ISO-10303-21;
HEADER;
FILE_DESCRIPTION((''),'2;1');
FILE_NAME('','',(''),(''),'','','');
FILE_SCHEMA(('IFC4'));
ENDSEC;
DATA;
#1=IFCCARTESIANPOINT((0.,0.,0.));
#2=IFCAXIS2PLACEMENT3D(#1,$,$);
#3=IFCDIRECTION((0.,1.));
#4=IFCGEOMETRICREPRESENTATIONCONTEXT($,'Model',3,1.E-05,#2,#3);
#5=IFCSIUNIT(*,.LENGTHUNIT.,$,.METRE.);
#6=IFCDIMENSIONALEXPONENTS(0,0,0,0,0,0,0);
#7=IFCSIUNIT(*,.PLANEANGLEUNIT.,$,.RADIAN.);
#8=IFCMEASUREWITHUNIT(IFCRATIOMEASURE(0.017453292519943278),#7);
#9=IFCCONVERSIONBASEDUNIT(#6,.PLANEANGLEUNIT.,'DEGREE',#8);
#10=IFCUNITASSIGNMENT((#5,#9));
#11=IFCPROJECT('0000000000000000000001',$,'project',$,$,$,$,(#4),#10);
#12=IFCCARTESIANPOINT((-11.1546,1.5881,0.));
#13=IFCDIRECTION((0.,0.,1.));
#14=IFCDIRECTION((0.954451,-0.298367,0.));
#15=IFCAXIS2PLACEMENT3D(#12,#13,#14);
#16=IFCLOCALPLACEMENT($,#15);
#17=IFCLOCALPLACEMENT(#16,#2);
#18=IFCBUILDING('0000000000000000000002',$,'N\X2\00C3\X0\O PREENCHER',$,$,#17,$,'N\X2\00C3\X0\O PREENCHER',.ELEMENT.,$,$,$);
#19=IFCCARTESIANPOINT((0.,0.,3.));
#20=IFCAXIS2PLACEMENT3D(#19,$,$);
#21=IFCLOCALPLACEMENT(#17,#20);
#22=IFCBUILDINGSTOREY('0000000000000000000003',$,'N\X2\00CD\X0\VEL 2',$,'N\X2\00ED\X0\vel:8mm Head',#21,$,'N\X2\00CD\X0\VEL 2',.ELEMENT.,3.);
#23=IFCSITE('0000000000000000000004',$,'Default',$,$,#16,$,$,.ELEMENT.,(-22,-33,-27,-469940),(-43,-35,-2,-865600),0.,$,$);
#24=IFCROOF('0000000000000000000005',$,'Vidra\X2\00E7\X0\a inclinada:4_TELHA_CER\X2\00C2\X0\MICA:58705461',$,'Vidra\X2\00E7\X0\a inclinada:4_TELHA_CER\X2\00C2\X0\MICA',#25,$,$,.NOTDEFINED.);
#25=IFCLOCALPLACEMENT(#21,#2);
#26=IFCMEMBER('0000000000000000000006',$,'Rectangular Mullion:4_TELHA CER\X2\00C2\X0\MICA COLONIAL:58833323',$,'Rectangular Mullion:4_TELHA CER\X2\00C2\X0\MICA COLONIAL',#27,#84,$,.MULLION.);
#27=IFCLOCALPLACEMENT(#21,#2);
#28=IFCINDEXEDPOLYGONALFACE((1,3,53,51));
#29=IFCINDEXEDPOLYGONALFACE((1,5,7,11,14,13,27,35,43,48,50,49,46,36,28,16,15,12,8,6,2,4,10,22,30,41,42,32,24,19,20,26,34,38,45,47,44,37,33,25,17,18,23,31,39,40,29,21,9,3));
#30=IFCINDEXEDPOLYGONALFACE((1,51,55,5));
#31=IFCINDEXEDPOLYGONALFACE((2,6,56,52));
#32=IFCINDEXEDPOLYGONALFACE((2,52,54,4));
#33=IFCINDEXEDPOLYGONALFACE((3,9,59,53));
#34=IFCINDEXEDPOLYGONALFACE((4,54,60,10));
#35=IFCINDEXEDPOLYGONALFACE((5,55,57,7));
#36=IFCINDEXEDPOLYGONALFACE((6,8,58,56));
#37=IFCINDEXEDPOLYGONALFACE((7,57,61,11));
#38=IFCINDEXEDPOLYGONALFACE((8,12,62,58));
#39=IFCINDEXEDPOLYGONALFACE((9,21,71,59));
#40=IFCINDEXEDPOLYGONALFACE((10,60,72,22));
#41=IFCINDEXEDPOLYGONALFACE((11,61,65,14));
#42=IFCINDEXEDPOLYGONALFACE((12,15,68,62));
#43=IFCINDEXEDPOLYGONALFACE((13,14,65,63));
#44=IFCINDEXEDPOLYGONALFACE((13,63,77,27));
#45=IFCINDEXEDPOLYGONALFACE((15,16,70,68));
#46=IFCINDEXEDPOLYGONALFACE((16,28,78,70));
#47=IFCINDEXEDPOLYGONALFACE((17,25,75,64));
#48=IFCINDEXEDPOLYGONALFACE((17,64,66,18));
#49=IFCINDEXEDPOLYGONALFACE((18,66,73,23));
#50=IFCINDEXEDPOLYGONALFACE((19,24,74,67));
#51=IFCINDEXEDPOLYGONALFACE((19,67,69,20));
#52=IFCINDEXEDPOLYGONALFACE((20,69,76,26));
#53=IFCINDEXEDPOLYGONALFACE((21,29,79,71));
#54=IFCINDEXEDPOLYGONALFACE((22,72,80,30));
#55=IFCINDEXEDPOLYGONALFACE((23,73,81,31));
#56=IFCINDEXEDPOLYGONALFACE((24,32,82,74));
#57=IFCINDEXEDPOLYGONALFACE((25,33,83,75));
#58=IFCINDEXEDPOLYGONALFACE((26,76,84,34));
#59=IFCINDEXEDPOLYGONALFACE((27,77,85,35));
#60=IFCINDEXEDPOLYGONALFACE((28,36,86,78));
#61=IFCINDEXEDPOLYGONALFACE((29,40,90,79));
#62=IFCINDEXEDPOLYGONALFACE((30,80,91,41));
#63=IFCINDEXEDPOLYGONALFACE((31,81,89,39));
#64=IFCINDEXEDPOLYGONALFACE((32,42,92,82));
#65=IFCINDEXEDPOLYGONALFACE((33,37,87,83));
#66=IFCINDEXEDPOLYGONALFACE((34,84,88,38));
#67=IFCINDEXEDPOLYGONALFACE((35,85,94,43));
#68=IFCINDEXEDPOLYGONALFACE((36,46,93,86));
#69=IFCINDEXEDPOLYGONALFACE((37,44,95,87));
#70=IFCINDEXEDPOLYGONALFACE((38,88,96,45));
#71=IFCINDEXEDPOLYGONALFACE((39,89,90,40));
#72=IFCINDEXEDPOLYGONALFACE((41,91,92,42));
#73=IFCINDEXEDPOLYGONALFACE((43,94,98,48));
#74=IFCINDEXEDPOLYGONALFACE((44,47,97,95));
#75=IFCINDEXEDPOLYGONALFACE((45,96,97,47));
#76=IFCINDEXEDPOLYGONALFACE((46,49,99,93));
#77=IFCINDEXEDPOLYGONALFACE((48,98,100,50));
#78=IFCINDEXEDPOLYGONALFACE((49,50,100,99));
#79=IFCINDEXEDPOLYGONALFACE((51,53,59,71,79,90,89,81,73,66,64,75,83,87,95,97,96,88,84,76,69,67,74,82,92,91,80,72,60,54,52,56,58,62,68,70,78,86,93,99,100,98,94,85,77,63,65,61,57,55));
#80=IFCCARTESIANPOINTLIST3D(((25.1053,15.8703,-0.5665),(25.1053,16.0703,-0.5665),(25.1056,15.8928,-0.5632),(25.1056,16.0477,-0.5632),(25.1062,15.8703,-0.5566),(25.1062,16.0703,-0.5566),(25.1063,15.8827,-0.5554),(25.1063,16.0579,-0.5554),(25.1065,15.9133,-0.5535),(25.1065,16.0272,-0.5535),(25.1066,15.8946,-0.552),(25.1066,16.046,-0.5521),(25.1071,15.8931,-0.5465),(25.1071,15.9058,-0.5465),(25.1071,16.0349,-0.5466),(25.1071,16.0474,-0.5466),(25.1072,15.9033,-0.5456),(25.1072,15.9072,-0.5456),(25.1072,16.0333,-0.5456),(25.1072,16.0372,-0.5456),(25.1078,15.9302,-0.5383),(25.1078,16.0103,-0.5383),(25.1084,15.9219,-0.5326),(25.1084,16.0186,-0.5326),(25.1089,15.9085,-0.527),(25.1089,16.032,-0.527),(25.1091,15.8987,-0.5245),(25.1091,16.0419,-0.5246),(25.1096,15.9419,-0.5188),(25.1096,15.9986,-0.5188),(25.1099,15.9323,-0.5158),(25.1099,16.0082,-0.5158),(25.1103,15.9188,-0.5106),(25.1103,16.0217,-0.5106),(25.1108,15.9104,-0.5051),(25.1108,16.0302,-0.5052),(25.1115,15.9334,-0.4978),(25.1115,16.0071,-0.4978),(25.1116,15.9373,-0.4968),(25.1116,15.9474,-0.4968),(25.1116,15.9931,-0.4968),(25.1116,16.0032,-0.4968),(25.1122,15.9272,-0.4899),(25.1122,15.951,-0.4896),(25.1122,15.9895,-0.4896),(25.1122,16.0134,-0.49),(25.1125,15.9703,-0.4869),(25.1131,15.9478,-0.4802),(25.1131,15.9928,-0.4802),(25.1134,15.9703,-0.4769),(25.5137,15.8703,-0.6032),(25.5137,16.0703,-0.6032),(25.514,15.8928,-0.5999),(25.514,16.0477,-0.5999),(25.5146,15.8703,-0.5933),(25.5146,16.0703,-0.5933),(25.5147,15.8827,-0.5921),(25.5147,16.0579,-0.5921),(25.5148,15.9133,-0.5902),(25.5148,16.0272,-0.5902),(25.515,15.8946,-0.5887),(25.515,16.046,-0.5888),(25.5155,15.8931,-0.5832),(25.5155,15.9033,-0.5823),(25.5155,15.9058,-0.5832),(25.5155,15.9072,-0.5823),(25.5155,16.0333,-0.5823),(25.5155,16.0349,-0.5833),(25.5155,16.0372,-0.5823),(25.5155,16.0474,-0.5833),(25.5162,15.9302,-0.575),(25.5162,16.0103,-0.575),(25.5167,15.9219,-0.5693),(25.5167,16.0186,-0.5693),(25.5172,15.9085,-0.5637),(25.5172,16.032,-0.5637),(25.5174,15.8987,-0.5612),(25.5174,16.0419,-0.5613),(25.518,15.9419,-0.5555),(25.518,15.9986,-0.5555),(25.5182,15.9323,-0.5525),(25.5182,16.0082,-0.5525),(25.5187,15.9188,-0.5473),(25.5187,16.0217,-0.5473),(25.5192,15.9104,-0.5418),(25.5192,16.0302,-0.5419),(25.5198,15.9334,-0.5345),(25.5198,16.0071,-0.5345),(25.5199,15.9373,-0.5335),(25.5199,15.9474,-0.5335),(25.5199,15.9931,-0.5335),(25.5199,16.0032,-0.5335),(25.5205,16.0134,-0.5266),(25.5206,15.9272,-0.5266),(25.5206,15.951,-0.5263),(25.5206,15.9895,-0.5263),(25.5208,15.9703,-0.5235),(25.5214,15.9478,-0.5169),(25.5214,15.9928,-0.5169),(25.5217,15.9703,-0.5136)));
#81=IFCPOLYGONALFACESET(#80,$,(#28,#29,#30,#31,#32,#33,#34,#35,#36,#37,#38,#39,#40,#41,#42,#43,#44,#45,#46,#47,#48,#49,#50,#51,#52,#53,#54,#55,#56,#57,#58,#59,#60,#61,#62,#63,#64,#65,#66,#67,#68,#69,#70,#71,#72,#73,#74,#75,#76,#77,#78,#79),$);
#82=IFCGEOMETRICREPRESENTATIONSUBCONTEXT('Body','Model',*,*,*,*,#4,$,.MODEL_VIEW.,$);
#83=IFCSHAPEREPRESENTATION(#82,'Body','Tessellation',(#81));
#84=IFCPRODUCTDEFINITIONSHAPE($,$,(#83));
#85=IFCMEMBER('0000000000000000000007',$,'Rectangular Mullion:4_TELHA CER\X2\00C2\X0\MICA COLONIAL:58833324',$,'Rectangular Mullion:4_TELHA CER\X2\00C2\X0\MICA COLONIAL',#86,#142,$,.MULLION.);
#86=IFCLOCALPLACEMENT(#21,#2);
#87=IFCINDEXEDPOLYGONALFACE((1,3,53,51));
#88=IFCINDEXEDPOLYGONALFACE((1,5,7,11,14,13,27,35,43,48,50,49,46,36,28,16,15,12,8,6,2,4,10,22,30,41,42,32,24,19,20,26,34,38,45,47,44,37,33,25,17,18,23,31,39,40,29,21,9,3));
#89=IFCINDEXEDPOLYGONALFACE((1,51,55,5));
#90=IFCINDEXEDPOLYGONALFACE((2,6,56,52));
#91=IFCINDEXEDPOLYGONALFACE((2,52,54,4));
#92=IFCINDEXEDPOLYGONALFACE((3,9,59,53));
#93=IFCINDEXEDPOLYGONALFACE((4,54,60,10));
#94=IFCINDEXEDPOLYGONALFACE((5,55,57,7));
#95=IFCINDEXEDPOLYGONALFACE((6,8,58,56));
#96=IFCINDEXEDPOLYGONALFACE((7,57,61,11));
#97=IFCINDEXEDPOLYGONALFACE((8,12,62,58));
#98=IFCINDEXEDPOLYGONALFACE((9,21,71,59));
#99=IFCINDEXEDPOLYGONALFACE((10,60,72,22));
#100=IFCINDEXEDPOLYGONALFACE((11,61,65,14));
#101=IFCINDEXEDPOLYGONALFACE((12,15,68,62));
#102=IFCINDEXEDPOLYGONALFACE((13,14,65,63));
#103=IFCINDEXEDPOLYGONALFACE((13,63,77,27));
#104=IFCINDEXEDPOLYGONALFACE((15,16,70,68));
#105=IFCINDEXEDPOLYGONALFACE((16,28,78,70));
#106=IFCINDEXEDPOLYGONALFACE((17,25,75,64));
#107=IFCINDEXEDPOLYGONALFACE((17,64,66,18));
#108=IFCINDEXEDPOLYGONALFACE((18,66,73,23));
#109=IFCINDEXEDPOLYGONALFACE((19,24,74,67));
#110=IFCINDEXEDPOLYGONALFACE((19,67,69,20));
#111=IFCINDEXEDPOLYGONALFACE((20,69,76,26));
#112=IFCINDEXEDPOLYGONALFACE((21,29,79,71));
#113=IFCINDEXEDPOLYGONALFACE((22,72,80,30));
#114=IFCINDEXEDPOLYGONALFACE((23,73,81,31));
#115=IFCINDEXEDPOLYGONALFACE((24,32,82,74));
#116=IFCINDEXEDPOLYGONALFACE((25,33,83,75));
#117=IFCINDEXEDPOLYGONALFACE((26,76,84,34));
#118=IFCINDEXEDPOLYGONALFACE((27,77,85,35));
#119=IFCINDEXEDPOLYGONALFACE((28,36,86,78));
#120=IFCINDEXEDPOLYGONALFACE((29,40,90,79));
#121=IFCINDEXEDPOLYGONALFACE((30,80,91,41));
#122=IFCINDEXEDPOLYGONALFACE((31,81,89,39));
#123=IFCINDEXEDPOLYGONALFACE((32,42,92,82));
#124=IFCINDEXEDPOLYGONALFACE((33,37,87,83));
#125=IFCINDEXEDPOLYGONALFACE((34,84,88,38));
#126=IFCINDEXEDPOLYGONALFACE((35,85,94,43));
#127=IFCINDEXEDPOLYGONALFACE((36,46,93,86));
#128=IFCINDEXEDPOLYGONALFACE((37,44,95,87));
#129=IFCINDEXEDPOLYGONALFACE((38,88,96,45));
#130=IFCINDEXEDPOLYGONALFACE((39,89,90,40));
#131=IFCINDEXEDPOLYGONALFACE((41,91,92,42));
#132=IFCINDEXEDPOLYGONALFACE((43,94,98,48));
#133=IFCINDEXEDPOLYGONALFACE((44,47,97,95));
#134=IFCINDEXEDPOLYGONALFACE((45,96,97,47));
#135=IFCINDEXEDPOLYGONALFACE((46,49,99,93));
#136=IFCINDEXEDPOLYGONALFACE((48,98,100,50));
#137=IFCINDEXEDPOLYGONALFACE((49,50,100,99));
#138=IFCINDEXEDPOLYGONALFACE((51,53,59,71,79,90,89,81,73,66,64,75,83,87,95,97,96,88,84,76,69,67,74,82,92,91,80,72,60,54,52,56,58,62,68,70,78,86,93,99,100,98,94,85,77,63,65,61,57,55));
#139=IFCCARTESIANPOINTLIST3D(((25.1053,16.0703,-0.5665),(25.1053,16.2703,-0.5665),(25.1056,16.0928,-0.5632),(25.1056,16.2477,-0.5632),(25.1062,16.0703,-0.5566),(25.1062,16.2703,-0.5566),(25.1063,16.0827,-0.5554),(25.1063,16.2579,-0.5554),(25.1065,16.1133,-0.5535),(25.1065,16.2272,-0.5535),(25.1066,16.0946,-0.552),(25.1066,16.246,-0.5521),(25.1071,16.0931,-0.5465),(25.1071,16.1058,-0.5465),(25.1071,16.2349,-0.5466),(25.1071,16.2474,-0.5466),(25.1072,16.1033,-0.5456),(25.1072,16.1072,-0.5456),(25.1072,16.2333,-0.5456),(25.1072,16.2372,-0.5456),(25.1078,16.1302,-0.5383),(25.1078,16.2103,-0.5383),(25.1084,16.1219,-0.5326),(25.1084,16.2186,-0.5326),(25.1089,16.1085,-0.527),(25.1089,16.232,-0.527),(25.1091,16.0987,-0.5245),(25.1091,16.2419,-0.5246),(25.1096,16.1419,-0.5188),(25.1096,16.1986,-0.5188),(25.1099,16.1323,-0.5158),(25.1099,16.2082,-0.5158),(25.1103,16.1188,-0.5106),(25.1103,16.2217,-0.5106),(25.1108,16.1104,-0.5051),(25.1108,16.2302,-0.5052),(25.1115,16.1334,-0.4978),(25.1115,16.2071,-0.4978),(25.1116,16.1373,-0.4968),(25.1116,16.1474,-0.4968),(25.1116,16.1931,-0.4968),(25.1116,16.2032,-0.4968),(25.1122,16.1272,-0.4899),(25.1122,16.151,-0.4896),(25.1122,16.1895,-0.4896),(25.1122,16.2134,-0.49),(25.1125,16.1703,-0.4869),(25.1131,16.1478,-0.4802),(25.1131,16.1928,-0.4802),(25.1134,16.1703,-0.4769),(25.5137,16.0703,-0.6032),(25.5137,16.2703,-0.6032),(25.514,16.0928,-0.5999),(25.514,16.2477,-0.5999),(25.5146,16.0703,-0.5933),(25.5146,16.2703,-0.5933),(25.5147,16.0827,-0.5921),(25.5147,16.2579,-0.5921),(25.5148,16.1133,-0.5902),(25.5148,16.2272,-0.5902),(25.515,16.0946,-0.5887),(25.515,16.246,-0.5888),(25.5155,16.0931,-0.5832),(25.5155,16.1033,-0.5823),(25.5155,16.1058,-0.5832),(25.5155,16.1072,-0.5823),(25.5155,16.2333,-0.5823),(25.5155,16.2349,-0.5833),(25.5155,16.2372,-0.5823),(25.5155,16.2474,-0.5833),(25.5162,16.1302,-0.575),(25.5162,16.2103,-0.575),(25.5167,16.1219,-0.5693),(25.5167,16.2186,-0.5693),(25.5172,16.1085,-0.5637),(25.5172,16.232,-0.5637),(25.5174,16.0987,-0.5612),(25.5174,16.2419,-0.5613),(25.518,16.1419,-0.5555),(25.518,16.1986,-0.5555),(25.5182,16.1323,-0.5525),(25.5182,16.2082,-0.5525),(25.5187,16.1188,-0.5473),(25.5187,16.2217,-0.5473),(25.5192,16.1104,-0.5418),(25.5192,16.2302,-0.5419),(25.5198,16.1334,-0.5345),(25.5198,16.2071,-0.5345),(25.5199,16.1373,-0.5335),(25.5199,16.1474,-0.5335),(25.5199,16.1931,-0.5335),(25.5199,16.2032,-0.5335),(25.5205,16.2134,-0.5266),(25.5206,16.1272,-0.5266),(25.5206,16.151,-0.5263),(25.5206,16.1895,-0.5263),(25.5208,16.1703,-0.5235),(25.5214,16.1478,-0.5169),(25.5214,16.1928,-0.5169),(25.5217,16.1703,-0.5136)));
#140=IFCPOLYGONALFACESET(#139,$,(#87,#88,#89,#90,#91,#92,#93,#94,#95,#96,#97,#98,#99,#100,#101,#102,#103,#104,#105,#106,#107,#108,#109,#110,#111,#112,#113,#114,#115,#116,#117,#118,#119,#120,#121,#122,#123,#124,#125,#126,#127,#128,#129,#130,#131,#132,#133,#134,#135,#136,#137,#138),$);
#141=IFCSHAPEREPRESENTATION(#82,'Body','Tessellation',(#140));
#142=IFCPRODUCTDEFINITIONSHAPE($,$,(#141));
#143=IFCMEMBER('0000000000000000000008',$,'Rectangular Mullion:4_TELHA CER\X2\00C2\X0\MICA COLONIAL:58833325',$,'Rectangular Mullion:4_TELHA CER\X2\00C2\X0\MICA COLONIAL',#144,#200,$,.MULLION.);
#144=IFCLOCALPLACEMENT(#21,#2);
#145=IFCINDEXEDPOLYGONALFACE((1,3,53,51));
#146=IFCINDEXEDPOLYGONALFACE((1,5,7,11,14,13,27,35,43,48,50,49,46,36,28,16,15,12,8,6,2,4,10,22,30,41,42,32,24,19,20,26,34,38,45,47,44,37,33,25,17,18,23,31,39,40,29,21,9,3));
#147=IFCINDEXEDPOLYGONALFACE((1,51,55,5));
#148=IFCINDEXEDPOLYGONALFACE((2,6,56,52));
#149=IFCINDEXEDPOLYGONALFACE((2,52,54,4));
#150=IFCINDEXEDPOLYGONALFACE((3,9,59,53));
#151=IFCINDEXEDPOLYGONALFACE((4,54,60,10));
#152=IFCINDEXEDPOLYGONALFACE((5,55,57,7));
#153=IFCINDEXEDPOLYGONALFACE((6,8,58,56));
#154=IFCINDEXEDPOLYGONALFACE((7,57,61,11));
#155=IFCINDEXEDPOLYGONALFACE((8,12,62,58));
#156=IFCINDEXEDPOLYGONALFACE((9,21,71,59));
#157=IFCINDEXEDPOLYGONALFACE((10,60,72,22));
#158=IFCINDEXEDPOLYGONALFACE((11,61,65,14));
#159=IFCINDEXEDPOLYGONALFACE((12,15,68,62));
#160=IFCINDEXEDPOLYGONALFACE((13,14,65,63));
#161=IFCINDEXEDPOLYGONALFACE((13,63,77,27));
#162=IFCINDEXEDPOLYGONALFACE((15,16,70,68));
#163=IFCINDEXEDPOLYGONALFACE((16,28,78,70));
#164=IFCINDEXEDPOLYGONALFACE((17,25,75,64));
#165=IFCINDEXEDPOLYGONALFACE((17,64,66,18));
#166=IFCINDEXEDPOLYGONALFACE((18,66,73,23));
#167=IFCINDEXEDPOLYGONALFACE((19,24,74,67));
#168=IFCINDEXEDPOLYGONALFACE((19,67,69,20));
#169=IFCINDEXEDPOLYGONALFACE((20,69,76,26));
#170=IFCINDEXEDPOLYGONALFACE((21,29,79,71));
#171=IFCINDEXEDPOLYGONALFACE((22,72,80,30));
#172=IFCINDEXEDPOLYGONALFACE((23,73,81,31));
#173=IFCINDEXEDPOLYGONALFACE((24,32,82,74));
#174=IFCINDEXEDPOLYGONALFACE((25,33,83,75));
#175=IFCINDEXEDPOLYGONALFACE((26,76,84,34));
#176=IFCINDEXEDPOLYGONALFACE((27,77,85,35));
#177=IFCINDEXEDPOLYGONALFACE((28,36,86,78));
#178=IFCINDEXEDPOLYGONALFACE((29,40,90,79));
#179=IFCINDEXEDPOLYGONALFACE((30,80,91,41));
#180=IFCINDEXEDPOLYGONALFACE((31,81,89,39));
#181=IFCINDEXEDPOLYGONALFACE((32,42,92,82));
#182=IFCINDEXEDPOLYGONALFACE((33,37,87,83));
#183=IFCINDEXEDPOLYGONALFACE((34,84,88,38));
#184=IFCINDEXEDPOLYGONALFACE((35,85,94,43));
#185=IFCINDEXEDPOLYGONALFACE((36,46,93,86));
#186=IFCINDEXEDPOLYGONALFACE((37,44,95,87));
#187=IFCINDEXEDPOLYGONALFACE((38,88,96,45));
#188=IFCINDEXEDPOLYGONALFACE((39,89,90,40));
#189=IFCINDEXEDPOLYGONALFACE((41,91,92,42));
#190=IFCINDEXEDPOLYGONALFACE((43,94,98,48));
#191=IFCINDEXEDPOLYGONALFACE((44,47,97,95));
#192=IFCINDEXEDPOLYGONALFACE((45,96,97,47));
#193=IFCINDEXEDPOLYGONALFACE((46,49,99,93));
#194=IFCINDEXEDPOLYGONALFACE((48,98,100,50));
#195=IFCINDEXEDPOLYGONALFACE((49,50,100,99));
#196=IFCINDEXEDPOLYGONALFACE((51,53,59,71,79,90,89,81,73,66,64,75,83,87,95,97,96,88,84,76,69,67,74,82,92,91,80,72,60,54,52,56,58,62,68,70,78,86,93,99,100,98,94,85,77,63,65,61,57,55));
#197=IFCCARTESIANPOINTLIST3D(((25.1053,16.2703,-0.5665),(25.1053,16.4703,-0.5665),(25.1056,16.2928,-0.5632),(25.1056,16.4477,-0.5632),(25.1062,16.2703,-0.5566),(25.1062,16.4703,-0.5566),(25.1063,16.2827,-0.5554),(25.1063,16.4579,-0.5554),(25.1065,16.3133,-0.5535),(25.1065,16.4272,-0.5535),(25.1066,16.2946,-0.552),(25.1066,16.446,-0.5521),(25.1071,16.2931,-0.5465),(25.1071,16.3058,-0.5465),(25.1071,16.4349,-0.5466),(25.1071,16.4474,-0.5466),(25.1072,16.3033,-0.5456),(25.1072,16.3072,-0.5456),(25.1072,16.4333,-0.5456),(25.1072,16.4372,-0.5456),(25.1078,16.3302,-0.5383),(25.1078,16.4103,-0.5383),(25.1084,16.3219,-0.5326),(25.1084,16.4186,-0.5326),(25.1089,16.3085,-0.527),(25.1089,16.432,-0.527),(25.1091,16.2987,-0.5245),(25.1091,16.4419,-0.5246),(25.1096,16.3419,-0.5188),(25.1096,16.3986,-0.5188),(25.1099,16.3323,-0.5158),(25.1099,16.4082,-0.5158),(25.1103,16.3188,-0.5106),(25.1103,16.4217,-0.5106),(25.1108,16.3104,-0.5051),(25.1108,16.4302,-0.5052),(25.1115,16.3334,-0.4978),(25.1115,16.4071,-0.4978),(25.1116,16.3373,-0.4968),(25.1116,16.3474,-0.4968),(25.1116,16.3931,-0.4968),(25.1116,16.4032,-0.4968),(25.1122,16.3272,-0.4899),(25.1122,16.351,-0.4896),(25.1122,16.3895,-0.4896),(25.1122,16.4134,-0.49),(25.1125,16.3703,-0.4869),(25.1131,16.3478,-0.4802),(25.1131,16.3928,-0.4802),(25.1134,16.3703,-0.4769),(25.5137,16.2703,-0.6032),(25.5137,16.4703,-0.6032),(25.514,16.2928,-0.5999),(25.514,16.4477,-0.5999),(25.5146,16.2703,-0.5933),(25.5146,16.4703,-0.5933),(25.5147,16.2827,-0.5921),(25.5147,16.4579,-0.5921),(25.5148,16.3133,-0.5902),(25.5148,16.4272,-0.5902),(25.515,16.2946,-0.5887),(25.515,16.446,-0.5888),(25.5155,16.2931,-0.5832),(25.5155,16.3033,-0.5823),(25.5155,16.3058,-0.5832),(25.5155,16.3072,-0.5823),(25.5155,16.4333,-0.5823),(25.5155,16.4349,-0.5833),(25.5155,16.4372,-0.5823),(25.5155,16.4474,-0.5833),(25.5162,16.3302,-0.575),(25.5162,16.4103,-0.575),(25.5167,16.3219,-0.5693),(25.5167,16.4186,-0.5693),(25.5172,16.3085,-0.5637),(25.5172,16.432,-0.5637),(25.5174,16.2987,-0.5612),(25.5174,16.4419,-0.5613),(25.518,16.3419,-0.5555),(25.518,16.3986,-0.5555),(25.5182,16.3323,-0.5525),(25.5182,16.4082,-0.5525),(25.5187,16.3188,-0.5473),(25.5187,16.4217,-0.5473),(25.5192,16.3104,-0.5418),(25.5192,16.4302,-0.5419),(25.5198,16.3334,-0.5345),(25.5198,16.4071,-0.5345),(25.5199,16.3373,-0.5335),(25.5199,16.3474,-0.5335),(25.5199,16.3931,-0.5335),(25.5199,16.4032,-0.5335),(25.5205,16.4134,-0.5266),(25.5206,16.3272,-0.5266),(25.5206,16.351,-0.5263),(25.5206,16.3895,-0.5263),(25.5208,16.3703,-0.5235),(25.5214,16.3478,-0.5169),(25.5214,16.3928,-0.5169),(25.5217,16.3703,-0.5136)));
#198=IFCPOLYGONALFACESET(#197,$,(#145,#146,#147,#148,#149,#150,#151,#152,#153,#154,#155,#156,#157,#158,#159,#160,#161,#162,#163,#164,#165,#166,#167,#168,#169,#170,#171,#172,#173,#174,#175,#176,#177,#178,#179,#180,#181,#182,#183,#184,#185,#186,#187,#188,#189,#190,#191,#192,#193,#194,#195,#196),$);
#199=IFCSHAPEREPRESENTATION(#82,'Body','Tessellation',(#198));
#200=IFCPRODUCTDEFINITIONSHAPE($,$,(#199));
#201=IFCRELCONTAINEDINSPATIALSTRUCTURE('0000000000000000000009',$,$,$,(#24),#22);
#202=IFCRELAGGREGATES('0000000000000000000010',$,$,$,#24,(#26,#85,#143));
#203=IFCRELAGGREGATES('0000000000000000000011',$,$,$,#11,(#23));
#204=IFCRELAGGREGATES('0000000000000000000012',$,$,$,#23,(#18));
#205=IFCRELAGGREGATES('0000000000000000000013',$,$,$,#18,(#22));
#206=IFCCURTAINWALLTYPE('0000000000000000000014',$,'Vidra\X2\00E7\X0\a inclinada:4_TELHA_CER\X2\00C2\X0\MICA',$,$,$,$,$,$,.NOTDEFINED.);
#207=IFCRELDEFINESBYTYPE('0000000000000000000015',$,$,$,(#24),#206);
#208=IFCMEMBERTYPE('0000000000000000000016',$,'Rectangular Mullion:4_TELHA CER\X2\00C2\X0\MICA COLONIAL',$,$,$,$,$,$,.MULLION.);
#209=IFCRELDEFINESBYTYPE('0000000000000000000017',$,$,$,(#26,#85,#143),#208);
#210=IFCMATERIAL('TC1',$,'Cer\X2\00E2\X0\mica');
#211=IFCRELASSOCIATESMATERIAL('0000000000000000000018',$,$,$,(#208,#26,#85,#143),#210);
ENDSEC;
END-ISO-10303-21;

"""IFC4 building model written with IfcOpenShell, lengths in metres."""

from ifc_helpers import new_model, entity, si_unit, converted_unit, direction, frame, origin, place, context, subcontext, project, spatial, line, arc, indexed_curve, outline, extrude, source, transform, mapped, material, type_object, type_shapes, element, aggregate, save


model = new_model("IFC4")

# Units and contexts
model_context = context("Model", 3, precision=1e-05, world=origin(), true_north=direction((0.0, 1.0)))
body_context = subcontext(model_context, "Body", "Model", "MODEL_VIEW")
ifc_project = project(units=[si_unit("LENGTHUNIT", "METRE"), converted_unit("PLANEANGLEUNIT", "DEGREE", entity("IfcRatioMeasure", 0.017453292519943278), si_unit("PLANEANGLEUNIT", "RADIAN"), dimensions=[0, 0, 0, 0, 0, 0, 0])], contexts=[model_context])

# Site, building, storey
site_placement = place(None, frame((-11.1546, 1.5881, 0.0), z_axis=(0.0, 0.0, 1.0), x_axis=(0.954451, -0.298367, 0.0)))
site = spatial("IfcSite", under=ifc_project, at=site_placement, Name="Default", CompositionType="ELEMENT", RefLatitude=(-22, -33, -27, -469940), RefLongitude=(-43, -35, -2, -865600), RefElevation=0.0)
building_placement = place(site_placement, origin())
building = spatial("IfcBuilding", under=site, at=building_placement, Name="NÃO PREENCHER", LongName="NÃO PREENCHER", CompositionType="ELEMENT")
storey_placement = place(building_placement, frame((0.0, 0.0, 3.0)))
storey = spatial("IfcBuildingStorey", under=building, at=storey_placement, Name="NÍVEL 2", ObjectType="Nível:8mm Head", LongName="NÍVEL 2", CompositionType="ELEMENT", Elevation=3.0)

# Roof, members
curtain_wall_type = type_object("IfcCurtainWallType", Name="Vidraça inclinada:4_TELHA_CERÂMICA", PredefinedType="NOTDEFINED")
roof_placement = place(storey_placement, frame((0.0, 0.0, -3.0)))
roof = element("IfcRoof", 1, at=roof_placement, inside=storey, type_object=curtain_wall_type, Name="Vidraça inclinada:4_TELHA_CERÂMICA:58705461", ObjectType="Vidraça inclinada:4_TELHA_CERÂMICA", PredefinedType="NOTDEFINED")
ifc_material = material(Name="TC1", Category="Cerâmica")
member_type = type_object("IfcMemberType", Name="Rectangular Mullion:4_TELHA CERÂMICA COLONIAL", PredefinedType="MULLION", material=ifc_material)
shared_shape = source(origin(), body_context, "Body", "SweptSolid", [
    extrude(outline(indexed_curve([(-0.029, -0.1), (-0.019, -0.1), (-0.0164, -0.0815), (-0.0089, -0.0645), (-0.0089, -0.0771), (0.061, 0.0), (-0.009, 0.0771), (-0.009, 0.0646), (-0.0165, 0.0816), (-0.019, 0.1), (-0.029, 0.1), (-0.0089, 0.0479), (0.041, 0.0229), (0.041, 0.0329), (0.0131, 0.0425), (-0.008, 0.0631), (-0.008, 0.067), (0.051, 0.0), (-0.008, -0.067), (-0.008, -0.0631), (0.0131, -0.0425), (0.041, -0.0329), (0.041, -0.0229), (-0.0089, -0.0479)], segments=[line(1, 2), arc(2, 3, 4), line(4, 5), arc(5, 6, 7), line(7, 8), arc(8, 9, 10), line(10, 11), arc(11, 12, 13), line(13, 14), arc(14, 15, 16), line(16, 17), arc(17, 18, 19), line(19, 20), arc(20, 21, 22), line(22, 23), arc(23, 24, 1)], self_intersect=False)), frame((0.0, -0.029, -0.41), z_axis=(0.0, 0.0, 1.0), x_axis=(0.0, -1.0, 0.0)), (0.0, 0.0, 1.0), 0.41),
])
type_shapes(member_type, [shared_shape])
member_1_placement = place(roof_placement, frame((25.1053, 15.9703, 2.4335), z_axis=(-0.99599, 0.0, 0.089469), x_axis=(0.0, 1.0, 0.0)))
member_1 = element("IfcMember", 2, at=member_1_placement, type_object=member_type, material=ifc_material, Name="Rectangular Mullion:4_TELHA CERÂMICA COLONIAL:58833323", ObjectType="Rectangular Mullion:4_TELHA CERÂMICA COLONIAL", PredefinedType="MULLION", context=body_context, shape_type="MappedRepresentation", body=[
    mapped(shared_shape, transform((0.0, 0.0, 0.0), scale=1.0)),
])
member_2_placement = place(roof_placement, frame((25.1053, 16.1703, 2.4335), z_axis=(-0.99599, 0.0, 0.089469), x_axis=(0.0, 1.0, 0.0)))
member_2 = element("IfcMember", 3, at=member_2_placement, type_object=member_type, material=ifc_material, Name="Rectangular Mullion:4_TELHA CERÂMICA COLONIAL:58833324", ObjectType="Rectangular Mullion:4_TELHA CERÂMICA COLONIAL", PredefinedType="MULLION", context=body_context, shape_type="MappedRepresentation", body=[
    mapped(shared_shape, transform((0.0, 0.0, 0.0), scale=1.0)),
])
member_3_placement = place(roof_placement, frame((25.1053, 16.3703, 2.4335), z_axis=(-0.99599, 0.0, 0.089469), x_axis=(0.0, 1.0, 0.0)))
member_3 = element("IfcMember", 4, at=member_3_placement, type_object=member_type, material=ifc_material, Name="Rectangular Mullion:4_TELHA CERÂMICA COLONIAL:58833325", ObjectType="Rectangular Mullion:4_TELHA CERÂMICA COLONIAL", PredefinedType="MULLION", context=body_context, shape_type="MappedRepresentation", body=[
    mapped(shared_shape, transform((0.0, 0.0, 0.0), scale=1.0)),
])
aggregate(roof, [member_1, member_2, member_3])

save(model, "model.ifc")
